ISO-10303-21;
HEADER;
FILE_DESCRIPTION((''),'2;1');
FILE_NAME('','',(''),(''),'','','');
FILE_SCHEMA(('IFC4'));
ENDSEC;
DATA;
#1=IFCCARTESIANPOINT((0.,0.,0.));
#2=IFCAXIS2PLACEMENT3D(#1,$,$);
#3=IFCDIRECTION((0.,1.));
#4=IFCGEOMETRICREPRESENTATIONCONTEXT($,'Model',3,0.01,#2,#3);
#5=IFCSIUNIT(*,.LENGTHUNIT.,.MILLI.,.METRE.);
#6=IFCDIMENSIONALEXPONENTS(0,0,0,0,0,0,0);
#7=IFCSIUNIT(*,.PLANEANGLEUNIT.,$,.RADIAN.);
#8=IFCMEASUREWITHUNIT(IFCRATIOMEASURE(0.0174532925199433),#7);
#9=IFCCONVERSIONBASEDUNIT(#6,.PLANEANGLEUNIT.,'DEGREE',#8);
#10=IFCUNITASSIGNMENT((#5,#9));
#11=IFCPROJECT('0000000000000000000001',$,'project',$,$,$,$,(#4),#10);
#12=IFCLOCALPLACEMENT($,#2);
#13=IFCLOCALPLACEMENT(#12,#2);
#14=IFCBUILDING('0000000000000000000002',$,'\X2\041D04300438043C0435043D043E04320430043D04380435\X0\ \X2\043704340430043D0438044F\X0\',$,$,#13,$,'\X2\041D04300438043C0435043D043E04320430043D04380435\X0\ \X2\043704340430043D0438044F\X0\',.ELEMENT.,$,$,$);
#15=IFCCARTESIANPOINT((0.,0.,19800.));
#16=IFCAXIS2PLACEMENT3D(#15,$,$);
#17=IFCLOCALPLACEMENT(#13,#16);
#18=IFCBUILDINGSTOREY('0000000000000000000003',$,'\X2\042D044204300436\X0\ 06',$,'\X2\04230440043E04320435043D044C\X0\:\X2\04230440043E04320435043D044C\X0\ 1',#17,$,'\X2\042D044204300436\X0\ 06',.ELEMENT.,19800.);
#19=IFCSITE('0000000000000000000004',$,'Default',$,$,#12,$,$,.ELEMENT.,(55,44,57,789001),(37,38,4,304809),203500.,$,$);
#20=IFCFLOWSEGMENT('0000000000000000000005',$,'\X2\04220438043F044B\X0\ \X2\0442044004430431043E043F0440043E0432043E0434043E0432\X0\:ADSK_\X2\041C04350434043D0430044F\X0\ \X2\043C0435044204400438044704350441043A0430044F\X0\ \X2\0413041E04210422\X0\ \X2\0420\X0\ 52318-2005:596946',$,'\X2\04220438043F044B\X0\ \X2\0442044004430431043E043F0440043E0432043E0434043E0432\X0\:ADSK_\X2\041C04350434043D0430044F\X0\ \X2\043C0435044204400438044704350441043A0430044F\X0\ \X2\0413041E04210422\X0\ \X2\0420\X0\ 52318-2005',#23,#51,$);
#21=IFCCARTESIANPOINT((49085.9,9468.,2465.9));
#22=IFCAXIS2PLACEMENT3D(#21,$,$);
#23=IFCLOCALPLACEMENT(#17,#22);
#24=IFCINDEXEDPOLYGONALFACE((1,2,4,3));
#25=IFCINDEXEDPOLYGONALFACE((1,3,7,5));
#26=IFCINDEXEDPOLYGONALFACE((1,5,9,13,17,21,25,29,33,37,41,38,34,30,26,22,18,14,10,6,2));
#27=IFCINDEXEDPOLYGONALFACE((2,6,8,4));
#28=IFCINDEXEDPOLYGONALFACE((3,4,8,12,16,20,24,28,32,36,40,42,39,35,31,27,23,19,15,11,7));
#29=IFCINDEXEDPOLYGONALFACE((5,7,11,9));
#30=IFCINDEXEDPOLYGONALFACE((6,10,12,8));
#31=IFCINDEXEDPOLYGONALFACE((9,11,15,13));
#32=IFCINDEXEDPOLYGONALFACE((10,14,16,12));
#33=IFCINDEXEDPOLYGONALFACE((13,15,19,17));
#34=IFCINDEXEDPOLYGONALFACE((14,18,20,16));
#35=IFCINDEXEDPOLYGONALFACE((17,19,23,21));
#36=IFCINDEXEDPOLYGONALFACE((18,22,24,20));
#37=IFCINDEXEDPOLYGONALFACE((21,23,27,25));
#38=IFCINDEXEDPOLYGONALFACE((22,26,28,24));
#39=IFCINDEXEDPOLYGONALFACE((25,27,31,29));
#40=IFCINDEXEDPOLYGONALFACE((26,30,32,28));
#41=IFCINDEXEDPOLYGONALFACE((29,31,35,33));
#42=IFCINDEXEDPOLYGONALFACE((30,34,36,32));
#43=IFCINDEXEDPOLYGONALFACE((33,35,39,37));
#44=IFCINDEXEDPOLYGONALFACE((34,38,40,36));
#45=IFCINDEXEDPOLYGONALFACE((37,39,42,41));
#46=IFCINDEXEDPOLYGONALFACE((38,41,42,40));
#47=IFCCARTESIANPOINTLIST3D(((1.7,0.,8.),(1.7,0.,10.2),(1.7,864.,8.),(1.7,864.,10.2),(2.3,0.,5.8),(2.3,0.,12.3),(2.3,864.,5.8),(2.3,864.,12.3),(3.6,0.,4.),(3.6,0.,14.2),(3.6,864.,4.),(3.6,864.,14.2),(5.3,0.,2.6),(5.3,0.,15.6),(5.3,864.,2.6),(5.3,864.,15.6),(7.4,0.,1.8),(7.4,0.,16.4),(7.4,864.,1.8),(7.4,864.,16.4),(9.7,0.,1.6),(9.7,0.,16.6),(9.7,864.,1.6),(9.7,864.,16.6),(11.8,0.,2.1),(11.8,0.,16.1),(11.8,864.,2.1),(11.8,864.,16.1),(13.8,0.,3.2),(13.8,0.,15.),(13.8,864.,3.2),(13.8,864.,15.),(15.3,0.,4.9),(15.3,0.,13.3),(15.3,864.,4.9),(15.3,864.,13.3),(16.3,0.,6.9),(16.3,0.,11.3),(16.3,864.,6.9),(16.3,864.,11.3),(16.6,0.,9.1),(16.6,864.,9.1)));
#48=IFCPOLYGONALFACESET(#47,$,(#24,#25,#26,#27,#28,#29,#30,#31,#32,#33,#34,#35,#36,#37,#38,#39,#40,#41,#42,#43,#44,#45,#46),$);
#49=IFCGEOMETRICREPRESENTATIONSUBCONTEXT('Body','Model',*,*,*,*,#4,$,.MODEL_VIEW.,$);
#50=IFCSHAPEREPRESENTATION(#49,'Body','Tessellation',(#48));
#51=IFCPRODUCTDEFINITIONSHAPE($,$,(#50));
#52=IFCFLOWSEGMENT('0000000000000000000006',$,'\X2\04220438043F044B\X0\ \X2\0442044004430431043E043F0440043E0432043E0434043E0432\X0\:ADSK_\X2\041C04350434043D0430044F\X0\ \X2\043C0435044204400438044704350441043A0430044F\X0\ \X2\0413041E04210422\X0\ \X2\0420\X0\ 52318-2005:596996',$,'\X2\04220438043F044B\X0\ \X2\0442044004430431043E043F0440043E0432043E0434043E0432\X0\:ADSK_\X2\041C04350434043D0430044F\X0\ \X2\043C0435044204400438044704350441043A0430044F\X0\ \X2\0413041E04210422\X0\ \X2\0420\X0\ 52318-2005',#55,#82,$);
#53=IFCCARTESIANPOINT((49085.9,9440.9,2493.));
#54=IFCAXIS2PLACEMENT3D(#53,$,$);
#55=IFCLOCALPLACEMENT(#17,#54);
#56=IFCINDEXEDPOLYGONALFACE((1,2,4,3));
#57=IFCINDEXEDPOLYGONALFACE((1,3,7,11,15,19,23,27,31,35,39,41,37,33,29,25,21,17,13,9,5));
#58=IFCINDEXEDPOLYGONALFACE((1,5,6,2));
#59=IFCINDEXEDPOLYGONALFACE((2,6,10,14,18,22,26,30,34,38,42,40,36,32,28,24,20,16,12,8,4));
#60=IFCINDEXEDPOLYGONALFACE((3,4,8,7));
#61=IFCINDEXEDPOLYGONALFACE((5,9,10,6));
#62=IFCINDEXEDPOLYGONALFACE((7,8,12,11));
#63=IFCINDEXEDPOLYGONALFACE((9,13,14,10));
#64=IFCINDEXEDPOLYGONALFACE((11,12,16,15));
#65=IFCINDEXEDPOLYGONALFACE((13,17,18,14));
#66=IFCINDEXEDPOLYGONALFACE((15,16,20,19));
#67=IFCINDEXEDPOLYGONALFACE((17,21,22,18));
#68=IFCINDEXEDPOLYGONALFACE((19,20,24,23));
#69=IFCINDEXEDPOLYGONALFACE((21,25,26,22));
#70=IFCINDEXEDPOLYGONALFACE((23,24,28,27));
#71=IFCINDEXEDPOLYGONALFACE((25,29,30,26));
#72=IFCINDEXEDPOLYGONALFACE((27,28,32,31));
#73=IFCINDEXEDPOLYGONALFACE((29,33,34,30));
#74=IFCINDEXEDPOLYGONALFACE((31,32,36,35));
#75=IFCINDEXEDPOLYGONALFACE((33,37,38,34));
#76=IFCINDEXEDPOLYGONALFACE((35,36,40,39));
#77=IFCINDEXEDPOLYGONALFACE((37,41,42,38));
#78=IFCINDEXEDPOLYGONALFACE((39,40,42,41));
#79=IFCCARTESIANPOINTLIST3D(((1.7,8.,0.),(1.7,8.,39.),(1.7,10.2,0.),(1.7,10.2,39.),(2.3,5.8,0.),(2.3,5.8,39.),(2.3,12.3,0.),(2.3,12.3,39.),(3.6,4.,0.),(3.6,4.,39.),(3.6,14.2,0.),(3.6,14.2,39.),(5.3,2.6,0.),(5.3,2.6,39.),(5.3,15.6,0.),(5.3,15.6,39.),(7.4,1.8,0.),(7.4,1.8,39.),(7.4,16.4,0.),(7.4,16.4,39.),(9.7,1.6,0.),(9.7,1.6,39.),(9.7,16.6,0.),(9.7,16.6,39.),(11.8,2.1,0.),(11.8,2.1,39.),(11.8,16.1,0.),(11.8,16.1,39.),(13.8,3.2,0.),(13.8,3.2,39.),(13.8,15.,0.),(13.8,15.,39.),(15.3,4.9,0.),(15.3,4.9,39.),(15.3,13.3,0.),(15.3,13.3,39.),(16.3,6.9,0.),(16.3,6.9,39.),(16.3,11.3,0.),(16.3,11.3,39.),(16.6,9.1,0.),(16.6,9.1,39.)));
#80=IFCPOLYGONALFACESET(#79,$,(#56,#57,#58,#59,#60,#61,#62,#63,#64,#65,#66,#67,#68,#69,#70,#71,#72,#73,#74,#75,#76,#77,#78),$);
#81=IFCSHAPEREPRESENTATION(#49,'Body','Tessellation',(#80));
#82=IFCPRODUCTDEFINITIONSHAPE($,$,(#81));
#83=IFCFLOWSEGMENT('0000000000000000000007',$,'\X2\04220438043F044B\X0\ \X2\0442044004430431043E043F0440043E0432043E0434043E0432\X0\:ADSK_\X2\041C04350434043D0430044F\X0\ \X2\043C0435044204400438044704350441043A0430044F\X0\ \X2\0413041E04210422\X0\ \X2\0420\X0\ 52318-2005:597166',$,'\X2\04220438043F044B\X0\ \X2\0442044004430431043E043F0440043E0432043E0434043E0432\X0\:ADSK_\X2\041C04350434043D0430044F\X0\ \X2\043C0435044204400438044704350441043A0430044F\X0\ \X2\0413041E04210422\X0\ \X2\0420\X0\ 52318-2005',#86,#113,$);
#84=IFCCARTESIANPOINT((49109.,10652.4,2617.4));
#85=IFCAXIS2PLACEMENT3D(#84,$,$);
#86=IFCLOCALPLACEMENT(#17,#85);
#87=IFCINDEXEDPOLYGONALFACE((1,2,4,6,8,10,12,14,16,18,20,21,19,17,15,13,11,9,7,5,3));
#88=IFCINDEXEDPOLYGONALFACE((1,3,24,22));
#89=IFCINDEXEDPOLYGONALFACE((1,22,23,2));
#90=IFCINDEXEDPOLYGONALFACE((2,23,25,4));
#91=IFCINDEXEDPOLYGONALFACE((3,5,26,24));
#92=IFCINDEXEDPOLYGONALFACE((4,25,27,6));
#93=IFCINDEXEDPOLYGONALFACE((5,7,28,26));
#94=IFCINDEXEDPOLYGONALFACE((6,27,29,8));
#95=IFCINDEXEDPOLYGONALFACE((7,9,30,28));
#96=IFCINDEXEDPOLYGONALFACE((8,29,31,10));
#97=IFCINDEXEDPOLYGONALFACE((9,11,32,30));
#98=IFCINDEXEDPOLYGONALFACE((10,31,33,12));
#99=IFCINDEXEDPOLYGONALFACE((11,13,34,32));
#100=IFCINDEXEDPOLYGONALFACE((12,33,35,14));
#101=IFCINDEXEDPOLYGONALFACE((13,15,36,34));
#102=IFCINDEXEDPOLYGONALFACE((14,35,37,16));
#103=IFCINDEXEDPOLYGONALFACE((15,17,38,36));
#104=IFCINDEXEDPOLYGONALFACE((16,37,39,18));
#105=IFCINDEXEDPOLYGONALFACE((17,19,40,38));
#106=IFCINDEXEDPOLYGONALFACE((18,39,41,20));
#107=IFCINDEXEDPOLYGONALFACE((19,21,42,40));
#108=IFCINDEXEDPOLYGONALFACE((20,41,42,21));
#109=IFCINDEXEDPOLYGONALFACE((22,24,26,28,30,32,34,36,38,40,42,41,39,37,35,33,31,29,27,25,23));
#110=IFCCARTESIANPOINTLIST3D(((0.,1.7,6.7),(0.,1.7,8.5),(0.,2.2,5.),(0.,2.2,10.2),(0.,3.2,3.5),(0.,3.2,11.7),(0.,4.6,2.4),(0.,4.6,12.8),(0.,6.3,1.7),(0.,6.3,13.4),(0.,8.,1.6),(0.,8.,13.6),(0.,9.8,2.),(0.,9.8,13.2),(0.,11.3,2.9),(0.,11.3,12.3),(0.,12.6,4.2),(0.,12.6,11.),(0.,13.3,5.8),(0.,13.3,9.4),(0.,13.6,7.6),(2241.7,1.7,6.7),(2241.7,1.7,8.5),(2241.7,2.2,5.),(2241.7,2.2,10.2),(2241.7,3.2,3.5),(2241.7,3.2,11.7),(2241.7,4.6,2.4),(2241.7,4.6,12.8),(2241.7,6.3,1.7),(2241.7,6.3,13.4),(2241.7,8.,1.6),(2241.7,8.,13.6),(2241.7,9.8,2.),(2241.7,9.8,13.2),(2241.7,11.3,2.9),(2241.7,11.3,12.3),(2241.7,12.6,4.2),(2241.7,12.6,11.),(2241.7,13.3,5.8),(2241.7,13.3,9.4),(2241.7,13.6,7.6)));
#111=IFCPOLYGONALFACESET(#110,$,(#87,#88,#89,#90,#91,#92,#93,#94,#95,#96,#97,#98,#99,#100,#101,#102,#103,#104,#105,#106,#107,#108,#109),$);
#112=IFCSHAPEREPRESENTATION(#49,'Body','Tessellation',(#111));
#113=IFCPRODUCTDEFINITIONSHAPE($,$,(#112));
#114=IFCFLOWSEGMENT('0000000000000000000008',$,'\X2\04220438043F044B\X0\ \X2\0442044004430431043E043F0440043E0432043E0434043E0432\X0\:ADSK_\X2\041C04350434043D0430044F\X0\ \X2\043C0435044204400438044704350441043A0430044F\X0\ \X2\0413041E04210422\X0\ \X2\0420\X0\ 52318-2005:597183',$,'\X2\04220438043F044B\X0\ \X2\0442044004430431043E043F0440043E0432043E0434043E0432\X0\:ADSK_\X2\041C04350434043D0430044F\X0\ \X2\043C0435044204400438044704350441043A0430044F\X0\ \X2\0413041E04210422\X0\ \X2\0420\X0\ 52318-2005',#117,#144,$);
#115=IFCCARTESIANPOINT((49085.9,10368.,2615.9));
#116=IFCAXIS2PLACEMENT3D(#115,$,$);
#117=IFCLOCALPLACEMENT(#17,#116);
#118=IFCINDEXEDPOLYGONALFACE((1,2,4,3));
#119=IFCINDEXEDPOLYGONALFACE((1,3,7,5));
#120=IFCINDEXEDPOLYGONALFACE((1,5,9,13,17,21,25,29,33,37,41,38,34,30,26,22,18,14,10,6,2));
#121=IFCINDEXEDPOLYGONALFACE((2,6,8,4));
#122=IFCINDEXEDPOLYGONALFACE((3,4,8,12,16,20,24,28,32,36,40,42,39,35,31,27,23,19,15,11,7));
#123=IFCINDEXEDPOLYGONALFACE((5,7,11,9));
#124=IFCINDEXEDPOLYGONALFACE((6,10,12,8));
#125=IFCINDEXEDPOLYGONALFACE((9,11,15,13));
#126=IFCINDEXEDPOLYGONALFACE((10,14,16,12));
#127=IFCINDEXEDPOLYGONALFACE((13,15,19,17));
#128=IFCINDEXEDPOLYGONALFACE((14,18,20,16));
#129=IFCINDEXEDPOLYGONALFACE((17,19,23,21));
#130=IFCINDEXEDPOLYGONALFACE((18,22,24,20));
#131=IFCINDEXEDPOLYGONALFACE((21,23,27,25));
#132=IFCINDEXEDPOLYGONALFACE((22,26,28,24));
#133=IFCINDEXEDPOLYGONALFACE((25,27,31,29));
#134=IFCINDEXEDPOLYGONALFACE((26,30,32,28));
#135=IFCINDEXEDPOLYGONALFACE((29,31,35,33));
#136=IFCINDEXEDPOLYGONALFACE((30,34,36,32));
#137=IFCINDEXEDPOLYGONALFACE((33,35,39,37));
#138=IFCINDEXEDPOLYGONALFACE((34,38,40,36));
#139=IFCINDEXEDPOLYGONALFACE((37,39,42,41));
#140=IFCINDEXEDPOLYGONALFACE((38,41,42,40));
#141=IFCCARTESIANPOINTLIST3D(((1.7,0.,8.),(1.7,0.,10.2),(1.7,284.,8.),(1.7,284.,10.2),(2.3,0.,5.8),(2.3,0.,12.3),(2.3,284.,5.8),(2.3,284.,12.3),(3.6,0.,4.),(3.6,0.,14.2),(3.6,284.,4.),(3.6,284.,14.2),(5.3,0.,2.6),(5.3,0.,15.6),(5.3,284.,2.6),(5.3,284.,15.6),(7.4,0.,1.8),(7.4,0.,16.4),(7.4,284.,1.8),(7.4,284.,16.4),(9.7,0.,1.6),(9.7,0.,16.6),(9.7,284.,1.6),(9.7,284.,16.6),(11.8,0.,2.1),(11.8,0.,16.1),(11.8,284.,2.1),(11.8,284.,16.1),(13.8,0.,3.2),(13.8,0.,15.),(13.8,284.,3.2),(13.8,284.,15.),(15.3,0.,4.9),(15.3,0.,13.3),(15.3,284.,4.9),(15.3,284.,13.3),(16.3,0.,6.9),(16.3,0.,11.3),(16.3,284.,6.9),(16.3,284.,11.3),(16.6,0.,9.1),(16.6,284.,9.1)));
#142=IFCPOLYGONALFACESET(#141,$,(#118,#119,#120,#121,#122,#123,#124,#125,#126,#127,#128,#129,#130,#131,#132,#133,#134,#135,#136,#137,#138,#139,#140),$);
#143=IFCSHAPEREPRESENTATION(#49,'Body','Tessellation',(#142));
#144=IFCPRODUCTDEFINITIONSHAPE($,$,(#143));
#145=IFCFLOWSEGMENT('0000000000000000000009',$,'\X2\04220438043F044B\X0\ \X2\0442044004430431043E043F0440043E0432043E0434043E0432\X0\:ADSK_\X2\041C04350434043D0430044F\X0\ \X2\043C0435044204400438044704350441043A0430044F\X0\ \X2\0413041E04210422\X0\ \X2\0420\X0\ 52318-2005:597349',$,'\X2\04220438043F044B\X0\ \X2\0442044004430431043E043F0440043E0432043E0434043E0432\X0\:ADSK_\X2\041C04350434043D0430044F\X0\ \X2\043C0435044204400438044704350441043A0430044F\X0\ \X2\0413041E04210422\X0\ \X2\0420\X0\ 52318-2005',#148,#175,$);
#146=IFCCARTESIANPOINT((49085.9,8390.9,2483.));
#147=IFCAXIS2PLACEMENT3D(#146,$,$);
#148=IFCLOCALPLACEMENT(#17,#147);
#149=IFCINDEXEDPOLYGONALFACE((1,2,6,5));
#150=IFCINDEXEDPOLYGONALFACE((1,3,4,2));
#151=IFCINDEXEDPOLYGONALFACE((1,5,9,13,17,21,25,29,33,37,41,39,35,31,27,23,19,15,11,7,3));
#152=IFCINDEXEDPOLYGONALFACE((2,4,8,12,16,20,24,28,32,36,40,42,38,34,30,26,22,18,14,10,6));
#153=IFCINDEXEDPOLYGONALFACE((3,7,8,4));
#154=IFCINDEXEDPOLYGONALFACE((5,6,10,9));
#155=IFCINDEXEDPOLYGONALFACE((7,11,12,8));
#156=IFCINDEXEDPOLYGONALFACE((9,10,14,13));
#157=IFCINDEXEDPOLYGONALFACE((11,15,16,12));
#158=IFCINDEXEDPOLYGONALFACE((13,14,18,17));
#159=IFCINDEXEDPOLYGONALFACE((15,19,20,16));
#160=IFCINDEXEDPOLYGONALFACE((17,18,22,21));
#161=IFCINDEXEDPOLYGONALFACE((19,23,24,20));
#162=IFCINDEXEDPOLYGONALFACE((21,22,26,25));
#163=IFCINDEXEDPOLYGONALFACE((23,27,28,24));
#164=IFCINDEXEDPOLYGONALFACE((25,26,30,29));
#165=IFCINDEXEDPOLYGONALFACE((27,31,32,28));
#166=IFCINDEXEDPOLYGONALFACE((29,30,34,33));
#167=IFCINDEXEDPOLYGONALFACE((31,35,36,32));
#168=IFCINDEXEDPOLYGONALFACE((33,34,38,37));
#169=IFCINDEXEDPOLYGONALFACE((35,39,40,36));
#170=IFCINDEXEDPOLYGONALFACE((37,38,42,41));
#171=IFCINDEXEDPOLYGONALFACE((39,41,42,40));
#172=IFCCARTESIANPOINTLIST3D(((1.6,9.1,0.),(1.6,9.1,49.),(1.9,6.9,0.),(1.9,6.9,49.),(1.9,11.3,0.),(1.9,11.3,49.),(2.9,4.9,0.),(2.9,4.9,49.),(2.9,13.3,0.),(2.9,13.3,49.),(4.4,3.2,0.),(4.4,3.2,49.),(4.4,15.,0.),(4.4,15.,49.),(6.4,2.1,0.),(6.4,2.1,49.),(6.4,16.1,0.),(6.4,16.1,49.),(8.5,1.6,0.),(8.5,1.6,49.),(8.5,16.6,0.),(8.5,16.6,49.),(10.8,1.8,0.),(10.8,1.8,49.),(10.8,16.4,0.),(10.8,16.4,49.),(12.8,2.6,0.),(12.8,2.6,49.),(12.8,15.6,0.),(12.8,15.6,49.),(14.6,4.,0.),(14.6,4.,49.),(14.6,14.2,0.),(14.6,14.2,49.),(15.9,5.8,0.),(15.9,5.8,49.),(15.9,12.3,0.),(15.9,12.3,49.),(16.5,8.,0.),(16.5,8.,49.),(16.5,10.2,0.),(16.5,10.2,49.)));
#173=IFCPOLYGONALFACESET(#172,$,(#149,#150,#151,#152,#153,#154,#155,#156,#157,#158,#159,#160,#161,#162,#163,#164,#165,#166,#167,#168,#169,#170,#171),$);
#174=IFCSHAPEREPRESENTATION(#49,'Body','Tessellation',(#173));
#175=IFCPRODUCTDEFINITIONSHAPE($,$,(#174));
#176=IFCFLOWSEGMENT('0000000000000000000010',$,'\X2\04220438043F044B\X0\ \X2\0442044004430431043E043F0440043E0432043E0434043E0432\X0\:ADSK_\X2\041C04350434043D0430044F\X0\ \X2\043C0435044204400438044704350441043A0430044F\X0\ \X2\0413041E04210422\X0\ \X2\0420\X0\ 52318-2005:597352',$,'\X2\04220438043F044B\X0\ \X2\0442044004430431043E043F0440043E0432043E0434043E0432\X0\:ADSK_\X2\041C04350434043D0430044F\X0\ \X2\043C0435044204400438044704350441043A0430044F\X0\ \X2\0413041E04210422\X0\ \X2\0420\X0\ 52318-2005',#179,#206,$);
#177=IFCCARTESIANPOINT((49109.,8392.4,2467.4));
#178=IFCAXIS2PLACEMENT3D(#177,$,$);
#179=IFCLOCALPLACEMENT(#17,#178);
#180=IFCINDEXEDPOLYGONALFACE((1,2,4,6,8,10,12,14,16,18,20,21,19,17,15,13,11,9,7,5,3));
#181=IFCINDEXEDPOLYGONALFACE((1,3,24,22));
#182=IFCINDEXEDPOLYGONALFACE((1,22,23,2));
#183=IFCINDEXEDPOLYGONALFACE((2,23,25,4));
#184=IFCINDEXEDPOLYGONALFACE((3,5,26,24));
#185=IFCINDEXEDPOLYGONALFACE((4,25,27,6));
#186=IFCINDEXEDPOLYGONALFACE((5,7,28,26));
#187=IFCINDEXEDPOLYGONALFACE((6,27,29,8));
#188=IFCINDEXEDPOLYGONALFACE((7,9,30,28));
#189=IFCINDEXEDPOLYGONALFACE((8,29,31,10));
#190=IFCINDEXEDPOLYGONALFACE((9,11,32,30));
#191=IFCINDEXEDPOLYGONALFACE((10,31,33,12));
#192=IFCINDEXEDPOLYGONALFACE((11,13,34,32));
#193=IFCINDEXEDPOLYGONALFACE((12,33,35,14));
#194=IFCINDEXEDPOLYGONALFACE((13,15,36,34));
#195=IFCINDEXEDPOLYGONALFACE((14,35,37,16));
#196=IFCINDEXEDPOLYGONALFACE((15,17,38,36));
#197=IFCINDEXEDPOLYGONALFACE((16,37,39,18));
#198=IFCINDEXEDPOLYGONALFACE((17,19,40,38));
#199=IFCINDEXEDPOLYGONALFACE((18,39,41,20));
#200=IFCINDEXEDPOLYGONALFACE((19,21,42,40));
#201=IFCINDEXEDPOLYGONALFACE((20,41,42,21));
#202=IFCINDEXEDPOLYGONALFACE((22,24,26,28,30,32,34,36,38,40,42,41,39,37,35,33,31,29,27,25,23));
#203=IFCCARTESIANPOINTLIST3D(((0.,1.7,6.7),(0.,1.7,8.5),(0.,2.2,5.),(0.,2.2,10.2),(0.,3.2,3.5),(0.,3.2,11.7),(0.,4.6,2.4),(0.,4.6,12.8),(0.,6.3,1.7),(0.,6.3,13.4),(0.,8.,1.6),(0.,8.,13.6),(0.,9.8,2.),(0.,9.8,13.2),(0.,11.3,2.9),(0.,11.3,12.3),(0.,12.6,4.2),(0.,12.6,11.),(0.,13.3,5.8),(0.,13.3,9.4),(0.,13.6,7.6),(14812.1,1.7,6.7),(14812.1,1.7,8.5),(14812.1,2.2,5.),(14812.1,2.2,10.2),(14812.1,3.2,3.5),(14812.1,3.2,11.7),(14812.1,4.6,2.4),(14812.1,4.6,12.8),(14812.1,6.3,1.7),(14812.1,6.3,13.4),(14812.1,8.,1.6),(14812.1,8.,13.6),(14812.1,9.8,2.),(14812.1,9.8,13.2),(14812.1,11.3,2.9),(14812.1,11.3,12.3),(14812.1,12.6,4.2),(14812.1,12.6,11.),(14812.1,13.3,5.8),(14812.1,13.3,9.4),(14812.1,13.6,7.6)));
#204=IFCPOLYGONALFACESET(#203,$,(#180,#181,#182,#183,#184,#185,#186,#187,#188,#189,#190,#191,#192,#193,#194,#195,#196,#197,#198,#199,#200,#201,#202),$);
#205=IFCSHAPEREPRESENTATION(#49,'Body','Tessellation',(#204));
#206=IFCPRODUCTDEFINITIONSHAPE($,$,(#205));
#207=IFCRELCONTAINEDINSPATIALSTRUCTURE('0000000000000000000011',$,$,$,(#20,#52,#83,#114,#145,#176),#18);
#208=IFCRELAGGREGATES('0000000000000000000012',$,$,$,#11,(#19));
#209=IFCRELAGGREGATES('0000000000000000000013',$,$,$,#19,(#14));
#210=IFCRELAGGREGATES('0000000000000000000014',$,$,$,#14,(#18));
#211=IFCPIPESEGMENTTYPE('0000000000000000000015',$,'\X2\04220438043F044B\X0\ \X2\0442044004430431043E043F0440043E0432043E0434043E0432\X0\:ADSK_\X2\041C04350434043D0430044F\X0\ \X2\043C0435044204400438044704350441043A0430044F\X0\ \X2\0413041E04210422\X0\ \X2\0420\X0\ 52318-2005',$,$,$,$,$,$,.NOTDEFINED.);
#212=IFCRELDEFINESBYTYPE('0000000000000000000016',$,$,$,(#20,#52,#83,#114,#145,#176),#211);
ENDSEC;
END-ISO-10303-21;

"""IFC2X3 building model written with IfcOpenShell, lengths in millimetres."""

from ifc_helpers import new_model, entity, si_unit, converted_unit, direction, frame, origin, origin_2d_with_axis, place, context, subcontext, project, spatial, circle, extrude, type_object, element, save


model = new_model("IFC2X3")

# Units and contexts
model_context = context("Model", 3, precision=0.01, world=origin(), true_north=direction((0.0, 1.0)))
body_context = subcontext(model_context, "Body", "Model", "MODEL_VIEW")
ifc_project = project(units=[si_unit("LENGTHUNIT", "METRE", prefix="MILLI"), converted_unit("PLANEANGLEUNIT", "DEGREE", entity("IfcRatioMeasure", 0.0174532925199433), si_unit("PLANEANGLEUNIT", "RADIAN"), dimensions=[0, 0, 0, 0, 0, 0, 0])], contexts=[model_context])

# Site, building, storey
site_placement = place(None, frame((0.0, 0.0, 0.0)))
site = spatial("IfcSite", under=ifc_project, at=site_placement, Name="Default", CompositionType="ELEMENT", RefLatitude=(55, 44, 57, 789001), RefLongitude=(37, 38, 4, 304809), RefElevation=203500.0)
building_placement = place(site_placement, origin())
building = spatial("IfcBuilding", under=site, at=building_placement, Name="Наименование здания", LongName="Наименование здания", CompositionType="ELEMENT")
storey_placement = place(building_placement, frame((0.0, 0.0, 19800.0)))
storey = spatial("IfcBuildingStorey", under=building, at=storey_placement, Name="Этаж 06", ObjectType="Уровень:Уровень 1", LongName="Этаж 06", CompositionType="ELEMENT", Elevation=19800.0)

# Flow segments
pipe_segment_type = type_object("IfcPipeSegmentType", Name="Типы трубопроводов:ADSK_Медная метрическая ГОСТ Р 52318-2005", PredefinedType="NOTDEFINED")
flow_segment_1_placement = place(storey_placement, frame((49085.9, 9468.0, 2465.9)))
element("IfcFlowSegment", 1, at=flow_segment_1_placement, inside=storey, type_object=pipe_segment_type, Name="Типы трубопроводов:ADSK_Медная метрическая ГОСТ Р 52318-2005:596946", ObjectType="Типы трубопроводов:ADSK_Медная метрическая ГОСТ Р 52318-2005", context=body_context, shape_type="SweptSolid", body=[
    extrude(circle(Radius=7.5, at=origin_2d_with_axis()), frame((9.1, 0.0, 9.1), z_axis=(0.0, 1.0, 0.0), x_axis=(1.0, 0.0, 0.0)), (0.0, 0.0, 1.0), 864.0),
])
flow_segment_2_placement = place(storey_placement, frame((49085.9, 9440.9, 2493.0)))
element("IfcFlowSegment", 2, at=flow_segment_2_placement, inside=storey, type_object=pipe_segment_type, Name="Типы трубопроводов:ADSK_Медная метрическая ГОСТ Р 52318-2005:596996", ObjectType="Типы трубопроводов:ADSK_Медная метрическая ГОСТ Р 52318-2005", context=body_context, shape_type="SweptSolid", body=[
    extrude(circle(Radius=7.5, at=origin_2d_with_axis()), frame((9.1, 9.1, 0.0)), (0.0, 0.0, 1.0), 39.0),
])
flow_segment_3_placement = place(storey_placement, frame((49109.0, 10652.4, 2617.4)))
element("IfcFlowSegment", 3, at=flow_segment_3_placement, inside=storey, type_object=pipe_segment_type, Name="Типы трубопроводов:ADSK_Медная метрическая ГОСТ Р 52318-2005:597166", ObjectType="Типы трубопроводов:ADSK_Медная метрическая ГОСТ Р 52318-2005", context=body_context, shape_type="SweptSolid", body=[
    extrude(circle(Radius=6.0, at=origin_2d_with_axis()), frame((0.0, 7.6, 7.6), z_axis=(1.0, 0.0, 0.0), x_axis=(0.0, 1.0, 0.0)), (0.0, 0.0, 1.0), 2241.7),
])
flow_segment_4_placement = place(storey_placement, frame((49085.9, 10368.0, 2615.9)))
element("IfcFlowSegment", 4, at=flow_segment_4_placement, inside=storey, type_object=pipe_segment_type, Name="Типы трубопроводов:ADSK_Медная метрическая ГОСТ Р 52318-2005:597183", ObjectType="Типы трубопроводов:ADSK_Медная метрическая ГОСТ Р 52318-2005", context=body_context, shape_type="SweptSolid", body=[
    extrude(circle(Radius=7.5, at=origin_2d_with_axis()), frame((9.1, 0.0, 9.1), z_axis=(0.0, 1.0, 0.0), x_axis=(1.0, 0.0, 0.0)), (0.0, 0.0, 1.0), 284.0),
])
flow_segment_5_placement = place(storey_placement, frame((49085.9, 8390.9, 2483.0)))
element("IfcFlowSegment", 5, at=flow_segment_5_placement, inside=storey, type_object=pipe_segment_type, Name="Типы трубопроводов:ADSK_Медная метрическая ГОСТ Р 52318-2005:597349", ObjectType="Типы трубопроводов:ADSK_Медная метрическая ГОСТ Р 52318-2005", context=body_context, shape_type="SweptSolid", body=[
    extrude(circle(Radius=7.5, at=origin_2d_with_axis()), frame((9.1, 9.1, 0.0), z_axis=(0.0, 0.0, 1.0), x_axis=(-1.0, 0.0, 0.0)), (0.0, 0.0, 1.0), 49.0),
])
flow_segment_6_placement = place(storey_placement, frame((49109.0, 8392.4, 2467.4)))
element("IfcFlowSegment", 6, at=flow_segment_6_placement, inside=storey, type_object=pipe_segment_type, Name="Типы трубопроводов:ADSK_Медная метрическая ГОСТ Р 52318-2005:597352", ObjectType="Типы трубопроводов:ADSK_Медная метрическая ГОСТ Р 52318-2005", context=body_context, shape_type="SweptSolid", body=[
    extrude(circle(Radius=6.0, at=origin_2d_with_axis()), frame((0.0, 7.6, 7.6), z_axis=(1.0, 0.0, 0.0), x_axis=(0.0, 1.0, 0.0)), (0.0, 0.0, 1.0), 14812.1),
])

save(model, "model.ifc")
